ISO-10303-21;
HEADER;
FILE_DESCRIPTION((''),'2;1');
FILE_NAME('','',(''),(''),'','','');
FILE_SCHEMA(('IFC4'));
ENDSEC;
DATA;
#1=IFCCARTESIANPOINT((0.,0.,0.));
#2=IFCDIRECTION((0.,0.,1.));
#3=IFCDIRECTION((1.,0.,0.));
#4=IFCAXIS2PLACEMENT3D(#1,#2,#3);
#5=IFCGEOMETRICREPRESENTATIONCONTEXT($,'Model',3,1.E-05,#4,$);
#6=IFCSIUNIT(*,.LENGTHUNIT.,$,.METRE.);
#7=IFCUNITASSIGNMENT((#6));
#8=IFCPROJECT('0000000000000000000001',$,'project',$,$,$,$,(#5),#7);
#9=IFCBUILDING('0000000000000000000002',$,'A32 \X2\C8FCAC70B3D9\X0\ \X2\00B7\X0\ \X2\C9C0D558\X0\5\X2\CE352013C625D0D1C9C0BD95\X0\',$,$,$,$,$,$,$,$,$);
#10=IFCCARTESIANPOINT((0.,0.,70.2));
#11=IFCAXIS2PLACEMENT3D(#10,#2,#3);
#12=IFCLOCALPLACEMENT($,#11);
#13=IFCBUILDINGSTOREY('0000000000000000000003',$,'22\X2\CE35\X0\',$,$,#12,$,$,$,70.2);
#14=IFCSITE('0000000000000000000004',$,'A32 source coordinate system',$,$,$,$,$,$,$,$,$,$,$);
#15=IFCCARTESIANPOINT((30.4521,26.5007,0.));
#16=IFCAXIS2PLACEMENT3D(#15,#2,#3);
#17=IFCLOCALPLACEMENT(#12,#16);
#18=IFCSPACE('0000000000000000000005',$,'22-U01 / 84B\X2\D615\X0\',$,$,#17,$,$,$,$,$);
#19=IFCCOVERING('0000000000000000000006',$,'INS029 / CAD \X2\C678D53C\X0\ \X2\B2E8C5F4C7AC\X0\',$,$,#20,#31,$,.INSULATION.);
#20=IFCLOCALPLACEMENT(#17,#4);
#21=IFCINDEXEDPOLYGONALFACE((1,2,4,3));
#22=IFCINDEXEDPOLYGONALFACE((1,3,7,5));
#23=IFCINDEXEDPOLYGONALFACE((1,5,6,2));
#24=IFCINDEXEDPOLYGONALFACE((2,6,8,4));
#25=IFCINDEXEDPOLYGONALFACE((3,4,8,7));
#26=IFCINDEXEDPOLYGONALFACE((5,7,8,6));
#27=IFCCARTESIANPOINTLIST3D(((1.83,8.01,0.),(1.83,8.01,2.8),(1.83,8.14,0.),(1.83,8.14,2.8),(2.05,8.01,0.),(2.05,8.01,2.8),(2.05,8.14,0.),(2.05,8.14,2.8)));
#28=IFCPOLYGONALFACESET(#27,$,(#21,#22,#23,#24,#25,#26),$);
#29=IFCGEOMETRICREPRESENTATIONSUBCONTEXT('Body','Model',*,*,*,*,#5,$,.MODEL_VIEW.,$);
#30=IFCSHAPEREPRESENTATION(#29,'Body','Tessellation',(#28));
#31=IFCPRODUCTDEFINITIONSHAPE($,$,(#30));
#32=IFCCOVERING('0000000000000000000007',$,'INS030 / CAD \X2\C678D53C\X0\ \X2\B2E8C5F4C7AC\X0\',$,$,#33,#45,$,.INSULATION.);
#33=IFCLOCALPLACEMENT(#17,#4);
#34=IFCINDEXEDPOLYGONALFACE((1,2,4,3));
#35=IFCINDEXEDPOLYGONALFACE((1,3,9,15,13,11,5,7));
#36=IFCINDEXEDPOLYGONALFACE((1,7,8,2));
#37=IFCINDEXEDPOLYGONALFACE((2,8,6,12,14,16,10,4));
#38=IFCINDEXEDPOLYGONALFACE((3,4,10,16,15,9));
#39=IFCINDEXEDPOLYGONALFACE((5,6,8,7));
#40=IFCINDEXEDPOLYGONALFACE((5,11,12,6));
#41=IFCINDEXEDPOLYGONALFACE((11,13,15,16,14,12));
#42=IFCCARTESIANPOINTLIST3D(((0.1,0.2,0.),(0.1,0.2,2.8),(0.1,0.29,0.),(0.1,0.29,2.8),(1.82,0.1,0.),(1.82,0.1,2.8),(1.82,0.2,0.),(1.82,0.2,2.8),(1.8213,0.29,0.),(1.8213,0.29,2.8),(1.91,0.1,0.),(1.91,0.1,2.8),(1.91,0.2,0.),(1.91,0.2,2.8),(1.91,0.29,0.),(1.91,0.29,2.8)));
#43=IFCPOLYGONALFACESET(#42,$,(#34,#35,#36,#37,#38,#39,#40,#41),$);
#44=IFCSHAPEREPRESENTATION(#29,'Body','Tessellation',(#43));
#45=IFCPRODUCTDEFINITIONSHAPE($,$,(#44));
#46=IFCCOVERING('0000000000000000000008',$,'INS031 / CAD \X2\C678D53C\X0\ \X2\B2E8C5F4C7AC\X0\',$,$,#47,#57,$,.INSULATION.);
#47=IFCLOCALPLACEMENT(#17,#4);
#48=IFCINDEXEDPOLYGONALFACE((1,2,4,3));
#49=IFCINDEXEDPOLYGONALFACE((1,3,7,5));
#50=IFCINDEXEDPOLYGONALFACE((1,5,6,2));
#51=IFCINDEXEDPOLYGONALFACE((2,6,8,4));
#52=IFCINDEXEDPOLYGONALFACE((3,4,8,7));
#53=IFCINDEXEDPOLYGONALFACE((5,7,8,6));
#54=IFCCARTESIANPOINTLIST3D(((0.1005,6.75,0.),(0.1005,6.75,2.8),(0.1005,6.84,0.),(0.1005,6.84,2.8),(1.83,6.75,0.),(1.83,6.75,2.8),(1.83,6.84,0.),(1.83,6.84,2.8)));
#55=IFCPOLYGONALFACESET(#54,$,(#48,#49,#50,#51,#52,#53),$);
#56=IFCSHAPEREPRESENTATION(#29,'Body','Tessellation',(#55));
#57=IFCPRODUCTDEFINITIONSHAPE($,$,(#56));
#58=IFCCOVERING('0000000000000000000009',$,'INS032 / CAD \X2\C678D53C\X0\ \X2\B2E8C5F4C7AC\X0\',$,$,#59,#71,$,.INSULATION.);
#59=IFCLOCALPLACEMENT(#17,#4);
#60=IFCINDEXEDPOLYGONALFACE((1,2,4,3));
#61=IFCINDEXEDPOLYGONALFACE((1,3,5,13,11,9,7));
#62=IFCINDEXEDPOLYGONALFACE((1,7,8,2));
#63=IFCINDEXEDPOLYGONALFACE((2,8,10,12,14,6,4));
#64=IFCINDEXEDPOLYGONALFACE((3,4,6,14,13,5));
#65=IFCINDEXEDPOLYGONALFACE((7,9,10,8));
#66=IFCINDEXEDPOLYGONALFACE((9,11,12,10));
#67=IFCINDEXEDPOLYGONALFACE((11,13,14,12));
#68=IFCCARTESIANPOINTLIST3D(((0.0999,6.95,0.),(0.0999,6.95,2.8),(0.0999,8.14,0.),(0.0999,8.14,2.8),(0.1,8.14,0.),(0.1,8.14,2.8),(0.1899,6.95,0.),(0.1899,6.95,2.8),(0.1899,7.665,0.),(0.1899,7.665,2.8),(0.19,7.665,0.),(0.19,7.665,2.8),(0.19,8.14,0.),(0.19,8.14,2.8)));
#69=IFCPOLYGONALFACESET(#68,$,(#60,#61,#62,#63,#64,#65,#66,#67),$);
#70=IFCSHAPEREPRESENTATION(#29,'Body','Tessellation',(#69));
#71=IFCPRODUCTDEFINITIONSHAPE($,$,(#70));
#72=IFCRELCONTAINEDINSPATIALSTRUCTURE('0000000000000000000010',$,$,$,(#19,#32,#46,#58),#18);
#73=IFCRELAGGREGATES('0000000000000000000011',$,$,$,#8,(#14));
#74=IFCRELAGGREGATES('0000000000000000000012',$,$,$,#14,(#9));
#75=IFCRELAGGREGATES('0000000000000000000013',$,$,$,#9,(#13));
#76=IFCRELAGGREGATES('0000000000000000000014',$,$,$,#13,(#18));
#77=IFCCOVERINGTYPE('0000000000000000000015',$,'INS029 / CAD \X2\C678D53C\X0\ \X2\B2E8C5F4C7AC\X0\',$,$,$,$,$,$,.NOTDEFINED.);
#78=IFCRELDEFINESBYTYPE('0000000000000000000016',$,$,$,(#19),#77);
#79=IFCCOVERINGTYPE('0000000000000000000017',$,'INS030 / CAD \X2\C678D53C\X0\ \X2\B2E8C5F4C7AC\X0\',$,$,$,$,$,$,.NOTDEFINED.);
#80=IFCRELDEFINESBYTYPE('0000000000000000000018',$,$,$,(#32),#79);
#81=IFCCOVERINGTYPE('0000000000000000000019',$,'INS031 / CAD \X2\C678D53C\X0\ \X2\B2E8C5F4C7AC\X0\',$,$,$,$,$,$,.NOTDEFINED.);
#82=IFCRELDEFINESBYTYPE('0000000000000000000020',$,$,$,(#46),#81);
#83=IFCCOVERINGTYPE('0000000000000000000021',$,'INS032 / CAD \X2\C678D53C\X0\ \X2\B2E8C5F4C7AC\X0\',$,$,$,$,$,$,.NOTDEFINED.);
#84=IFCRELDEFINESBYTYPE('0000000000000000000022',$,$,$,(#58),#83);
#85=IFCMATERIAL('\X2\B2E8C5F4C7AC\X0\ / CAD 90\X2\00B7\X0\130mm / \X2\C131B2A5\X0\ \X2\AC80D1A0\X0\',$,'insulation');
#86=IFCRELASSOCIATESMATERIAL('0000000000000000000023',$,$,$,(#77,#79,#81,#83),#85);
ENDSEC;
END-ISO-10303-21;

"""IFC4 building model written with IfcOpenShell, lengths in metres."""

from ifc_helpers import new_model, si_unit, frame, origin, origin_with_axes, place, context, subcontext, project, spatial, polyline, outline, extrude, source, transform, mapped, material, type_object, type_shapes, element, save


model = new_model("IFC4")

# Units and contexts
model_context = context("Model", 3, precision=1e-05, world=origin_with_axes())
body_context = subcontext(model_context, "Body", "Model", "MODEL_VIEW")
ifc_project = project(units=[si_unit("LENGTHUNIT", "METRE")], contexts=[model_context])

# Site, building, storey, space
storey_placement = place(None, frame((0.0, 0.0, 70.2), z_axis=(0.0, 0.0, 1.0), x_axis=(1.0, 0.0, 0.0)))
space_placement = place(storey_placement, frame((30.4521, 26.5007, 0.0), z_axis=(0.0, 0.0, 1.0), x_axis=(1.0, 0.0, 0.0)))
site = spatial("IfcSite", under=ifc_project, Name="A32 source coordinate system")
building = spatial("IfcBuilding", under=site, Name="A32 주거동 · 지하5층–옥탑지붕")
storey = spatial("IfcBuildingStorey", under=building, at=storey_placement, Name="22층", Elevation=70.2)
space = spatial("IfcSpace", under=storey, at=space_placement, Name="22-U01 / 84B형")

# Coverings
ifc_material = material(Name="단열재 / CAD 90·130mm / 성능 검토", Category="insulation")
covering_type_1 = type_object("IfcCoveringType", Name="INS029 / CAD 외피 단열재", PredefinedType="NOTDEFINED", material=ifc_material)
shared_shape_1 = source(origin(), body_context, "Body", "SweptSolid", [
    extrude(outline(polyline([(1.83, 8.01), (1.83, 8.14), (2.05, 8.14), (2.05, 8.01), (1.83, 8.01)])), origin(), (0.0, 0.0, 1.0), 2.8),
])
type_shapes(covering_type_1, [shared_shape_1])
covering_1_placement = place(space_placement, origin_with_axes())
element("IfcCovering", 1, at=covering_1_placement, inside=space, type_object=covering_type_1, Name="INS029 / CAD 외피 단열재", PredefinedType="INSULATION", context=body_context, shape_type="MappedRepresentation", body=[
    mapped(shared_shape_1, transform((0.0, 0.0, 0.0), scale=1.0)),
])
covering_type_2 = type_object("IfcCoveringType", Name="INS030 / CAD 외피 단열재", PredefinedType="NOTDEFINED", material=ifc_material)
shared_shape_2 = source(origin(), body_context, "Body", "SweptSolid", [
    extrude(outline(polyline([(1.91, 0.2), (1.91, 0.1), (1.82, 0.1), (1.82, 0.2), (0.1, 0.2), (0.1, 0.29), (1.8213, 0.29), (1.91, 0.29), (1.91, 0.2)])), origin(), (0.0, 0.0, 1.0), 2.8),
])
type_shapes(covering_type_2, [shared_shape_2])
covering_2_placement = place(space_placement, origin_with_axes())
element("IfcCovering", 2, at=covering_2_placement, inside=space, type_object=covering_type_2, Name="INS030 / CAD 외피 단열재", PredefinedType="INSULATION", context=body_context, shape_type="MappedRepresentation", body=[
    mapped(shared_shape_2, transform((0.0, 0.0, 0.0), scale=1.0)),
])
covering_type_3 = type_object("IfcCoveringType", Name="INS031 / CAD 외피 단열재", PredefinedType="NOTDEFINED", material=ifc_material)
shared_shape_3 = source(origin(), body_context, "Body", "SweptSolid", [
    extrude(outline(polyline([(1.83, 6.75), (0.1005, 6.75), (0.1005, 6.84), (1.83, 6.84), (1.83, 6.75)])), origin(), (0.0, 0.0, 1.0), 2.8),
])
type_shapes(covering_type_3, [shared_shape_3])
covering_3_placement = place(space_placement, origin_with_axes())
element("IfcCovering", 3, at=covering_3_placement, inside=space, type_object=covering_type_3, Name="INS031 / CAD 외피 단열재", PredefinedType="INSULATION", context=body_context, shape_type="MappedRepresentation", body=[
    mapped(shared_shape_3, transform((0.0, 0.0, 0.0), scale=1.0)),
])
covering_type_4 = type_object("IfcCoveringType", Name="INS032 / CAD 외피 단열재", PredefinedType="NOTDEFINED", material=ifc_material)
shared_shape_4 = source(origin(), body_context, "Body", "SweptSolid", [
    extrude(outline(polyline([(0.1899, 6.95), (0.0999, 6.95), (0.0999, 8.14), (0.1, 8.14), (0.19, 8.14), (0.19, 7.665), (0.1899, 7.665), (0.1899, 6.95)])), origin(), (0.0, 0.0, 1.0), 2.8),
])
type_shapes(covering_type_4, [shared_shape_4])
covering_4_placement = place(space_placement, origin_with_axes())
element("IfcCovering", 4, at=covering_4_placement, inside=space, type_object=covering_type_4, Name="INS032 / CAD 외피 단열재", PredefinedType="INSULATION", context=body_context, shape_type="MappedRepresentation", body=[
    mapped(shared_shape_4, transform((0.0, 0.0, 0.0), scale=1.0)),
])

save(model, "model.ifc")
